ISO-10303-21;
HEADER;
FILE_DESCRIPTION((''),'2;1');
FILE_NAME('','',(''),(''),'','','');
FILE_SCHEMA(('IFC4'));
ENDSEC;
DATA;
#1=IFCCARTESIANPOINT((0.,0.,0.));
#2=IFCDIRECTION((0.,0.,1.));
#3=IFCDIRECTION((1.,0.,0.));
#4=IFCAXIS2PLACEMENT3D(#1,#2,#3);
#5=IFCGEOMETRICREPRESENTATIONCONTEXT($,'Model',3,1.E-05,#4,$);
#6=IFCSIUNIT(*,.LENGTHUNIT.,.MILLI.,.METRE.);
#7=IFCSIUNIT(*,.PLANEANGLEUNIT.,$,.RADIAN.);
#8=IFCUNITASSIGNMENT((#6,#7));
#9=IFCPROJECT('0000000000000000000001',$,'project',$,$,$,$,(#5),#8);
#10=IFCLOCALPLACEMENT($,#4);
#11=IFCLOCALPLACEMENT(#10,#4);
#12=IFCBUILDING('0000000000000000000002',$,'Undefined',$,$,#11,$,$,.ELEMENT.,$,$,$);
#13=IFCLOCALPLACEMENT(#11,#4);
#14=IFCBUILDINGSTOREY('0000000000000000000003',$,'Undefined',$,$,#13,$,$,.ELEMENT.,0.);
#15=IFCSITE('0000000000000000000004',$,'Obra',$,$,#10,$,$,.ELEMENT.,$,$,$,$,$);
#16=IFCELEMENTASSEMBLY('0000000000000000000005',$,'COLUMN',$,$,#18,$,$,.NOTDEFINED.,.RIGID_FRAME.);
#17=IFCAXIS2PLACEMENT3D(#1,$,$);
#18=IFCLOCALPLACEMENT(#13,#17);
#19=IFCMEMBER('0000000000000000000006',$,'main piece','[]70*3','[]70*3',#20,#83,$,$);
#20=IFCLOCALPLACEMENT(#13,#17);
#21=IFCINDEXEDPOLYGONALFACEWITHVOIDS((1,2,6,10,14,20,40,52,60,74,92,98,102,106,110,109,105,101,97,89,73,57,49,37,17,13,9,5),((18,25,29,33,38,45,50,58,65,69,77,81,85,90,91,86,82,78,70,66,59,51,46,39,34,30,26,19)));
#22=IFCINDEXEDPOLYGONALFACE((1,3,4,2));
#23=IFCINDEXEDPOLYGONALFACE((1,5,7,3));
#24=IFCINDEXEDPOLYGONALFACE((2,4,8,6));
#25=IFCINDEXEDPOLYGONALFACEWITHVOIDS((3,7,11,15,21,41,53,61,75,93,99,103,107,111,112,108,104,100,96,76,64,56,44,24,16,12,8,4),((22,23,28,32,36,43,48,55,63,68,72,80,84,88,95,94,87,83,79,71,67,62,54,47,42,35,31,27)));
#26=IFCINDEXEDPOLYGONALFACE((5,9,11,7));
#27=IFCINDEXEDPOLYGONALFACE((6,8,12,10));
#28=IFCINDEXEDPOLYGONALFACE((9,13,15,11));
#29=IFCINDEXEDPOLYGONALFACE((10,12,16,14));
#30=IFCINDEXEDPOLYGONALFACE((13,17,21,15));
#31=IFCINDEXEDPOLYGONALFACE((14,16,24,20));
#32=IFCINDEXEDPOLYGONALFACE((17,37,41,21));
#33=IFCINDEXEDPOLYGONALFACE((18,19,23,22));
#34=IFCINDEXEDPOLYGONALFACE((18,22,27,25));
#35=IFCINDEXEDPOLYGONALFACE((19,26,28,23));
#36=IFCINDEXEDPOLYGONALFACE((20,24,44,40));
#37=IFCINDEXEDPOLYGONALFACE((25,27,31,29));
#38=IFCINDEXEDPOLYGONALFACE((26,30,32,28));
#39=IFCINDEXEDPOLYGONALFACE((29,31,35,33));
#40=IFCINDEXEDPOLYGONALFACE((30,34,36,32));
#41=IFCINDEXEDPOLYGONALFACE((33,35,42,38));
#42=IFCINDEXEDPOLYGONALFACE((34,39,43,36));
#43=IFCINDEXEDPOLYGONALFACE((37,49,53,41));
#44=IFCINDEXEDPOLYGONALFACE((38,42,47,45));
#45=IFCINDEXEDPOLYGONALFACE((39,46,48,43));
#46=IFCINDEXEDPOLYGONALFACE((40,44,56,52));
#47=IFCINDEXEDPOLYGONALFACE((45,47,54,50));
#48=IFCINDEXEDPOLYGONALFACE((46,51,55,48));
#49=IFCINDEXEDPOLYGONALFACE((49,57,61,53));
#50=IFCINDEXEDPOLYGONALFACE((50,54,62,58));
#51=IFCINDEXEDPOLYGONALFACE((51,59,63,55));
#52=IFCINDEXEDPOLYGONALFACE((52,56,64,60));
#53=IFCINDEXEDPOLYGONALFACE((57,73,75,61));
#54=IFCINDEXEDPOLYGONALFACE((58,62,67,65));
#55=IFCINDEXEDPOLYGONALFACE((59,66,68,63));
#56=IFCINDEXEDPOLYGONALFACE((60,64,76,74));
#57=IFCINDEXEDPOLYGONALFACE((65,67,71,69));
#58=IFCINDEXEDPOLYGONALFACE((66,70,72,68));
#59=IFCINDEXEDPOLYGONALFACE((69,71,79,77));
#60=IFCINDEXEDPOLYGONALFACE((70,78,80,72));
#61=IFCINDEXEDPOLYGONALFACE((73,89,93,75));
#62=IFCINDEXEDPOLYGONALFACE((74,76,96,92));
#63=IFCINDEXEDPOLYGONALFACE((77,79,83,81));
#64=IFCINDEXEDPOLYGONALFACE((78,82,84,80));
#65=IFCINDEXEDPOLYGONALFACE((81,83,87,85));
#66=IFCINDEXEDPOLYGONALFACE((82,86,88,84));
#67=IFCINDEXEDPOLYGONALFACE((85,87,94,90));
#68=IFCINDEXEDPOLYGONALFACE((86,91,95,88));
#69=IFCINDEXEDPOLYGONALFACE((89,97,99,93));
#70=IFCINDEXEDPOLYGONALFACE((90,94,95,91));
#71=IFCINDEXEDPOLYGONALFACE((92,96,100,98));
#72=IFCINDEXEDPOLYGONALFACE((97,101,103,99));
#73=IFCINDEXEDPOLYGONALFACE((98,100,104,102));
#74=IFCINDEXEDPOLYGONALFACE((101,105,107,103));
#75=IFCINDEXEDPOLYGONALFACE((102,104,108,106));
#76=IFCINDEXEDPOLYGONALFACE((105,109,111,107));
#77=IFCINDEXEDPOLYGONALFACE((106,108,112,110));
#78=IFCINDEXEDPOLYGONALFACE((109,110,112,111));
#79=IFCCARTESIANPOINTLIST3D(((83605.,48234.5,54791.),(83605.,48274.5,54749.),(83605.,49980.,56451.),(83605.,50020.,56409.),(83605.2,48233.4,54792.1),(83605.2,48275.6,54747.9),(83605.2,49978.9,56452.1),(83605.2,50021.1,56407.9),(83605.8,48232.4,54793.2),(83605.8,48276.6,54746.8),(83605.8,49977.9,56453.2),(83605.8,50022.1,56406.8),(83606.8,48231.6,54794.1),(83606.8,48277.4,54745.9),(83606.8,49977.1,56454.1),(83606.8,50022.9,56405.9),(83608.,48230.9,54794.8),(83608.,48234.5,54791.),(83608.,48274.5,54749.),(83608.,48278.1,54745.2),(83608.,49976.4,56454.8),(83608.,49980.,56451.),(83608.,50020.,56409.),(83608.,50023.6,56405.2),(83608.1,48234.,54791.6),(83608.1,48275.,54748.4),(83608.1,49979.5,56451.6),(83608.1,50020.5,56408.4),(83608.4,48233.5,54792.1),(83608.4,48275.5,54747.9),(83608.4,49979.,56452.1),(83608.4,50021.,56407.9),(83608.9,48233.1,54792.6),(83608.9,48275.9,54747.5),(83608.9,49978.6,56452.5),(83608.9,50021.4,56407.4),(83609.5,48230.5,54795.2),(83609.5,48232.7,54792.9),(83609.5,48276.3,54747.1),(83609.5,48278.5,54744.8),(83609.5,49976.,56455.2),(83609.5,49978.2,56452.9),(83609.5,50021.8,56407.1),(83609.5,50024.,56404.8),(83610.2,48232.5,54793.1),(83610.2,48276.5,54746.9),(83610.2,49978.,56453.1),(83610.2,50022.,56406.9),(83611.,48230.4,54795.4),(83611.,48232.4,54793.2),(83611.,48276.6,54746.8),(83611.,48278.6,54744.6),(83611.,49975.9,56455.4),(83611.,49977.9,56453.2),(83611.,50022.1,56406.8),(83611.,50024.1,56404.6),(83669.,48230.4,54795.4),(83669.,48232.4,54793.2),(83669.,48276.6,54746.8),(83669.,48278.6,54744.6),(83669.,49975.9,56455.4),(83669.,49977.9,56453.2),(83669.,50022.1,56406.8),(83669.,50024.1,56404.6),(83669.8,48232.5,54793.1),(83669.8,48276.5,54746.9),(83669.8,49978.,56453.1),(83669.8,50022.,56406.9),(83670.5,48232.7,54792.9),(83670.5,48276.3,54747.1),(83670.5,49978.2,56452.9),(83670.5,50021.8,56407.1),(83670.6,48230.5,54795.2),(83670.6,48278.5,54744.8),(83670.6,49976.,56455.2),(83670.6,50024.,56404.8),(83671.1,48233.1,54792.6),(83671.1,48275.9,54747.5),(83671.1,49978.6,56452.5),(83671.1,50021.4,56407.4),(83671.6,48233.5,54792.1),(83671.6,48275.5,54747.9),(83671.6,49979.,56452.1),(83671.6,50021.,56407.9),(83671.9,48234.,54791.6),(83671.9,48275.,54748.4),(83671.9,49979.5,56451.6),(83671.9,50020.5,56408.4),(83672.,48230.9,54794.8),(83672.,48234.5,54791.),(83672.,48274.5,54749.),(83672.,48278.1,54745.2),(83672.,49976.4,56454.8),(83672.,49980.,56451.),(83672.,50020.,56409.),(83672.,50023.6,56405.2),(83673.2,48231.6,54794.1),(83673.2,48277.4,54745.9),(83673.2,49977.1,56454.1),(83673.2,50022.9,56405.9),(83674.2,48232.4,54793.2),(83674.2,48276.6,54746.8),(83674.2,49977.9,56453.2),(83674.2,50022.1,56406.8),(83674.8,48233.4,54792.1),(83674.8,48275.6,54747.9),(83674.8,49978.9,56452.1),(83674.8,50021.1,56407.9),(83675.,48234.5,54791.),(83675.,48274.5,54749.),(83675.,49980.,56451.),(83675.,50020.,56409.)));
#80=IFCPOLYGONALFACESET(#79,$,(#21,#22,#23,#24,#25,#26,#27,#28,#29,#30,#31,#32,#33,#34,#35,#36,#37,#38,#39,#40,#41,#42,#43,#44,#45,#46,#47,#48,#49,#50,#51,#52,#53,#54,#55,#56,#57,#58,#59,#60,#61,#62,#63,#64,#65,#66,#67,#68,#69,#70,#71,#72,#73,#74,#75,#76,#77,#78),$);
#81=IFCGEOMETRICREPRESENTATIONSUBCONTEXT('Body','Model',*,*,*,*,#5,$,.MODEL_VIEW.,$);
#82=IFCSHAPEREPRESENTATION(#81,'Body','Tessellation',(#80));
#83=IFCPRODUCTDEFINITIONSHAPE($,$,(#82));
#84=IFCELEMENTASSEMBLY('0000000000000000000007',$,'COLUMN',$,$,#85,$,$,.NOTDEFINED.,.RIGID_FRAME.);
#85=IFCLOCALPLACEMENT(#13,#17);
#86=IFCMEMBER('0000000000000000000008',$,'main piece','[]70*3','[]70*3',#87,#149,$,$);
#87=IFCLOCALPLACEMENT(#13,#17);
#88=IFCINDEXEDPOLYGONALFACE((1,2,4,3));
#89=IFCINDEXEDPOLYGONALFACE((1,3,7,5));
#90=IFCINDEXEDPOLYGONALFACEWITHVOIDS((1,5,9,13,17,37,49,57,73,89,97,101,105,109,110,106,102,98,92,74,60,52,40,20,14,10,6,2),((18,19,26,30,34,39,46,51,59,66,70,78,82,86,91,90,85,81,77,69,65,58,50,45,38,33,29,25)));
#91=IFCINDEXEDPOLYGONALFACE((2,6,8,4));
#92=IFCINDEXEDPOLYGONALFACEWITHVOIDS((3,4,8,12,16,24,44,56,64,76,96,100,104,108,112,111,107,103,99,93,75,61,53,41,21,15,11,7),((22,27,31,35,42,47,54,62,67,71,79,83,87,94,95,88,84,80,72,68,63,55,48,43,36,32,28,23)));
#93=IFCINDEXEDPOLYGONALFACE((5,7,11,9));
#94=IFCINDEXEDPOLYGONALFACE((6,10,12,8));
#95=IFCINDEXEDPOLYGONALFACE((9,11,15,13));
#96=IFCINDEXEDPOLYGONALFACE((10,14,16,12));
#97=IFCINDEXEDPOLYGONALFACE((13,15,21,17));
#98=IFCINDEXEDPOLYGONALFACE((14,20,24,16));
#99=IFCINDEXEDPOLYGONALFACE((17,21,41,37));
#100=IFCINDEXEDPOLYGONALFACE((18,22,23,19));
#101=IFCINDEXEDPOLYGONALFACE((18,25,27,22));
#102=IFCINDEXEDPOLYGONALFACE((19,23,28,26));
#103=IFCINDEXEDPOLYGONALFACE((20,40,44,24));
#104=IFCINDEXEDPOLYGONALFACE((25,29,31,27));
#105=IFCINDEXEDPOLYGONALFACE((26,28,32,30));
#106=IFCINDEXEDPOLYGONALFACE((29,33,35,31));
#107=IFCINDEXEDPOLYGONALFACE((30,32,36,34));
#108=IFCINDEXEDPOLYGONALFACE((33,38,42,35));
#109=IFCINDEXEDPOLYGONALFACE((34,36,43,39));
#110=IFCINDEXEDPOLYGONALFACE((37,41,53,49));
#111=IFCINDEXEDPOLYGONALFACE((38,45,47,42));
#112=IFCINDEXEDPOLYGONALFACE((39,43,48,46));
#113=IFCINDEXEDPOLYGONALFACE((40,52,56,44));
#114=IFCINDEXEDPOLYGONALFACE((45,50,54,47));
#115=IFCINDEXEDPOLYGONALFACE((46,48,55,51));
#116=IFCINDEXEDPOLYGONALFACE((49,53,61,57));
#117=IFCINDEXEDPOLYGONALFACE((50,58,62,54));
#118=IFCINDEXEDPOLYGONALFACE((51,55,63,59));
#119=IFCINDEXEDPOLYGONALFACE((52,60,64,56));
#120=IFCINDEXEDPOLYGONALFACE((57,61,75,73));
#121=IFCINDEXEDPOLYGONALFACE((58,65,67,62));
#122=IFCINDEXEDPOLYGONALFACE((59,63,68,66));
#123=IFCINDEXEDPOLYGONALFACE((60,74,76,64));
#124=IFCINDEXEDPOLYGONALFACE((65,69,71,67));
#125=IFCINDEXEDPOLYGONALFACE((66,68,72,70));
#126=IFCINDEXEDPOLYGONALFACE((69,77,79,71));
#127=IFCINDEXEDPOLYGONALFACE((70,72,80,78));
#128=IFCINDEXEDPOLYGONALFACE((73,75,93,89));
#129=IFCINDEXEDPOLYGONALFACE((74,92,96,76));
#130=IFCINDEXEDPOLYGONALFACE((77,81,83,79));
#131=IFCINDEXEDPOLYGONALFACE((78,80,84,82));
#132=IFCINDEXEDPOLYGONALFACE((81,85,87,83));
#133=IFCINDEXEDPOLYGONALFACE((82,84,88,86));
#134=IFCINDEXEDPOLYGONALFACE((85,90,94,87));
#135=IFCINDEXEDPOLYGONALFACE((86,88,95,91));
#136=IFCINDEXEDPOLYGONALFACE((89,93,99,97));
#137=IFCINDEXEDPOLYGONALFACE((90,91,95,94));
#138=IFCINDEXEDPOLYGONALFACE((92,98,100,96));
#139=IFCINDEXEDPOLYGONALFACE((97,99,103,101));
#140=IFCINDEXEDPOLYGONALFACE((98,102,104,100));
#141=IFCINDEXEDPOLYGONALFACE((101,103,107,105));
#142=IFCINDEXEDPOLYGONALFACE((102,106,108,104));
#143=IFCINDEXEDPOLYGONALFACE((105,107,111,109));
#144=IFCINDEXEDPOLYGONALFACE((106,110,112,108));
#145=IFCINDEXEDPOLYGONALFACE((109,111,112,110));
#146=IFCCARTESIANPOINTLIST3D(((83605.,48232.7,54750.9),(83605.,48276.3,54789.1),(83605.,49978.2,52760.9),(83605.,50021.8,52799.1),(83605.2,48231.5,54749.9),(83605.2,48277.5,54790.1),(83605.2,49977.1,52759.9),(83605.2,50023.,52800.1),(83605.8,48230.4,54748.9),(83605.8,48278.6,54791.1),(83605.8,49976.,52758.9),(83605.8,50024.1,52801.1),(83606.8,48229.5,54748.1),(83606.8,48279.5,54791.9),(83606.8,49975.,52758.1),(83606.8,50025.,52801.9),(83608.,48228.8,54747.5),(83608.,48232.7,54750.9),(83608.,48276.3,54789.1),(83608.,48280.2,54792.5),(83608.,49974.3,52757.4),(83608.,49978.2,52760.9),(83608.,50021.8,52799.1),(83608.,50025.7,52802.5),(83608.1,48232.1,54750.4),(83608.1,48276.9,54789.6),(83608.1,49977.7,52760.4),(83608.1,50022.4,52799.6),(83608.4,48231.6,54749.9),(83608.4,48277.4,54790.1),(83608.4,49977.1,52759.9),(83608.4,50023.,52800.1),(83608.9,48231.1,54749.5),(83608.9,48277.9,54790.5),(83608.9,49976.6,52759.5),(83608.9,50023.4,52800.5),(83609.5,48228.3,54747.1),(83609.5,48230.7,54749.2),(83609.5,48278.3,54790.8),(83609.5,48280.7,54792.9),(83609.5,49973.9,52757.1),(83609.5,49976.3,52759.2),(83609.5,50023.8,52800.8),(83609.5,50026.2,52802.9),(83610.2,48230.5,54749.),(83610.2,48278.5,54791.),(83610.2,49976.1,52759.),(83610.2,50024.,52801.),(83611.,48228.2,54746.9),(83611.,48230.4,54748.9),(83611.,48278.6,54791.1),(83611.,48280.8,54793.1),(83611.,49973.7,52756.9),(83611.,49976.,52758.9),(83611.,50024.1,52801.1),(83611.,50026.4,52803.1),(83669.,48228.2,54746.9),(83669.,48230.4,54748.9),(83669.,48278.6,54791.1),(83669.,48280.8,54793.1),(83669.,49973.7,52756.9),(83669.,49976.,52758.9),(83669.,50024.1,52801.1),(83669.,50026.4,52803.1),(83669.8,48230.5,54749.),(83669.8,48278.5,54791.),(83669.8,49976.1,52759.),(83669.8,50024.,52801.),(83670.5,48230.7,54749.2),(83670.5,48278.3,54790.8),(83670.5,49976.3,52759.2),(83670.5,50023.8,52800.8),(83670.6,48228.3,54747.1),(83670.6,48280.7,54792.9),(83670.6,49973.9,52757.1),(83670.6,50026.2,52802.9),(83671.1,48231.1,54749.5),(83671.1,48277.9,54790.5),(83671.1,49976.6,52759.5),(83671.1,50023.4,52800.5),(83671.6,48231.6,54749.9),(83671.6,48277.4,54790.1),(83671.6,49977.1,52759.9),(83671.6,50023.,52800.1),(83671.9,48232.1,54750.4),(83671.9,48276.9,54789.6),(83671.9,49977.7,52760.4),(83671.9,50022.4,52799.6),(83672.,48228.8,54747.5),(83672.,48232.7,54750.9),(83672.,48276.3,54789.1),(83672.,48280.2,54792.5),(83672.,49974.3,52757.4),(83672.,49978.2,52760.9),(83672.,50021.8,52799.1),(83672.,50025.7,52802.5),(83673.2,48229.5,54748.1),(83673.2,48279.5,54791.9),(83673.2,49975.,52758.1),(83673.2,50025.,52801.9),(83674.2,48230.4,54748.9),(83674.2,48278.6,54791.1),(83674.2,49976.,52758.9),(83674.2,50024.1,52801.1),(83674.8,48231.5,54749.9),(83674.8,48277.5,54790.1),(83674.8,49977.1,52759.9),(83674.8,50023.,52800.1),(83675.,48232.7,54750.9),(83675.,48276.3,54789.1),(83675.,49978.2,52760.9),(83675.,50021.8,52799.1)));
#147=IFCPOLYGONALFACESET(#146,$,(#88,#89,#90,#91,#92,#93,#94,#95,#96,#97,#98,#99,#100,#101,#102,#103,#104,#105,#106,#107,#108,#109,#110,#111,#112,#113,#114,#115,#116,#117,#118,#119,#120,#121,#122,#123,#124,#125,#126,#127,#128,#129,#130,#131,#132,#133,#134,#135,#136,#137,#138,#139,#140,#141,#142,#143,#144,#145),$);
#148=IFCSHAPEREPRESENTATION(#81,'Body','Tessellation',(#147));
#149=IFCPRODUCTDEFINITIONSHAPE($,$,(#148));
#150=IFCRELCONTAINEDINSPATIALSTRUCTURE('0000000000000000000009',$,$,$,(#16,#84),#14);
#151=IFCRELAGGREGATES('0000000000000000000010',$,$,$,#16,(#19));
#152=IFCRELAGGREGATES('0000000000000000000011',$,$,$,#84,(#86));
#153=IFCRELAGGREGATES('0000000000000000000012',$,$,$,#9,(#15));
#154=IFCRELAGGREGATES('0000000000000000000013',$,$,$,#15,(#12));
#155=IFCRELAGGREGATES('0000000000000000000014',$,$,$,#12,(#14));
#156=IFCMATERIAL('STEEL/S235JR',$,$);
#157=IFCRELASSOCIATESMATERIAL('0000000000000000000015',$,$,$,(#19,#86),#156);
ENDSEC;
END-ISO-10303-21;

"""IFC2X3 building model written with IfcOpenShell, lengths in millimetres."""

from ifc_helpers import new_model, si_unit, frame, origin_with_axes, origin_2d_with_axis, place, context, subcontext, project, spatial, hollow_rectangle, extrude, material, element, aggregate, save


model = new_model("IFC2X3")

# Units and contexts
model_context = context("Model", 3, precision=1e-05, world=origin_with_axes())
body_context = subcontext(model_context, "Body", "Model", "MODEL_VIEW")
ifc_project = project(units=[si_unit("LENGTHUNIT", "METRE", prefix="MILLI"), si_unit("PLANEANGLEUNIT", "RADIAN")], contexts=[model_context])

# Site, building, storey
site_placement = place(None, origin_with_axes())
site = spatial("IfcSite", under=ifc_project, at=site_placement, Name="Obra", CompositionType="ELEMENT")
building_placement = place(site_placement, origin_with_axes())
building = spatial("IfcBuilding", under=site, at=building_placement, Name="Undefined", CompositionType="ELEMENT")
storey_placement = place(building_placement, origin_with_axes())
storey = spatial("IfcBuildingStorey", under=building, at=storey_placement, Name="Undefined", CompositionType="ELEMENT", Elevation=0.0)

# Shared definitions
ifc_material = material(Name="STEEL/S235JR")

# Element assemblies, members
assembly_1_placement = place(storey_placement, origin_with_axes())
assembly_1 = element("IfcElementAssembly", 1, at=assembly_1_placement, inside=storey, Name="COLUMN", AssemblyPlace="NOTDEFINED", PredefinedType="RIGID_FRAME")
member_1_placement = place(assembly_1_placement, frame((83640.0, 48254.5, 54770.0), z_axis=(-1.0, 0.0, 0.0), x_axis=(0.0, 0.724633, 0.689135)))
member_1 = element("IfcMember", 2, at=member_1_placement, material=ifc_material, Name="main piece", Description="[]70*3", ObjectType="[]70*3", context=body_context, shape_type="SweptSolid", body=[
    extrude(hollow_rectangle(XDim=70.0, YDim=70.0, WallThickness=3.0, InnerFilletRadius=3.0, OuterFilletRadius=6.0, at=origin_2d_with_axis()), frame((2408.8, 0.0, 0.0), z_axis=(-1.0, 0.0, 0.0), x_axis=(0.0, -1.0, 0.0)), (0.0, 0.0, 1.0), 2408.8),
])
aggregate(assembly_1, [member_1])
assembly_2_placement = place(storey_placement, origin_with_axes())
assembly_2 = element("IfcElementAssembly", 3, at=assembly_2_placement, inside=storey, Name="COLUMN", AssemblyPlace="NOTDEFINED", PredefinedType="RIGID_FRAME")
member_2_placement = place(assembly_2_placement, frame((83640.0, 50000.0, 52780.0), z_axis=(1.0, 0.0, 0.0), x_axis=(0.0, -0.659423, 0.751772)))
member_2 = element("IfcMember", 4, at=member_2_placement, material=ifc_material, Name="main piece", Description="[]70*3", ObjectType="[]70*3", context=body_context, shape_type="SweptSolid", body=[
    extrude(hollow_rectangle(XDim=70.0, YDim=70.0, WallThickness=3.0, InnerFilletRadius=3.0, OuterFilletRadius=6.0, at=origin_2d_with_axis()), frame((2647.1, 0.0, 0.0), z_axis=(-1.0, 0.0, 0.0), x_axis=(0.0, -1.0, 0.0)), (0.0, 0.0, 1.0), 2647.1),
])
aggregate(assembly_2, [member_2])

save(model, "model.ifc")
